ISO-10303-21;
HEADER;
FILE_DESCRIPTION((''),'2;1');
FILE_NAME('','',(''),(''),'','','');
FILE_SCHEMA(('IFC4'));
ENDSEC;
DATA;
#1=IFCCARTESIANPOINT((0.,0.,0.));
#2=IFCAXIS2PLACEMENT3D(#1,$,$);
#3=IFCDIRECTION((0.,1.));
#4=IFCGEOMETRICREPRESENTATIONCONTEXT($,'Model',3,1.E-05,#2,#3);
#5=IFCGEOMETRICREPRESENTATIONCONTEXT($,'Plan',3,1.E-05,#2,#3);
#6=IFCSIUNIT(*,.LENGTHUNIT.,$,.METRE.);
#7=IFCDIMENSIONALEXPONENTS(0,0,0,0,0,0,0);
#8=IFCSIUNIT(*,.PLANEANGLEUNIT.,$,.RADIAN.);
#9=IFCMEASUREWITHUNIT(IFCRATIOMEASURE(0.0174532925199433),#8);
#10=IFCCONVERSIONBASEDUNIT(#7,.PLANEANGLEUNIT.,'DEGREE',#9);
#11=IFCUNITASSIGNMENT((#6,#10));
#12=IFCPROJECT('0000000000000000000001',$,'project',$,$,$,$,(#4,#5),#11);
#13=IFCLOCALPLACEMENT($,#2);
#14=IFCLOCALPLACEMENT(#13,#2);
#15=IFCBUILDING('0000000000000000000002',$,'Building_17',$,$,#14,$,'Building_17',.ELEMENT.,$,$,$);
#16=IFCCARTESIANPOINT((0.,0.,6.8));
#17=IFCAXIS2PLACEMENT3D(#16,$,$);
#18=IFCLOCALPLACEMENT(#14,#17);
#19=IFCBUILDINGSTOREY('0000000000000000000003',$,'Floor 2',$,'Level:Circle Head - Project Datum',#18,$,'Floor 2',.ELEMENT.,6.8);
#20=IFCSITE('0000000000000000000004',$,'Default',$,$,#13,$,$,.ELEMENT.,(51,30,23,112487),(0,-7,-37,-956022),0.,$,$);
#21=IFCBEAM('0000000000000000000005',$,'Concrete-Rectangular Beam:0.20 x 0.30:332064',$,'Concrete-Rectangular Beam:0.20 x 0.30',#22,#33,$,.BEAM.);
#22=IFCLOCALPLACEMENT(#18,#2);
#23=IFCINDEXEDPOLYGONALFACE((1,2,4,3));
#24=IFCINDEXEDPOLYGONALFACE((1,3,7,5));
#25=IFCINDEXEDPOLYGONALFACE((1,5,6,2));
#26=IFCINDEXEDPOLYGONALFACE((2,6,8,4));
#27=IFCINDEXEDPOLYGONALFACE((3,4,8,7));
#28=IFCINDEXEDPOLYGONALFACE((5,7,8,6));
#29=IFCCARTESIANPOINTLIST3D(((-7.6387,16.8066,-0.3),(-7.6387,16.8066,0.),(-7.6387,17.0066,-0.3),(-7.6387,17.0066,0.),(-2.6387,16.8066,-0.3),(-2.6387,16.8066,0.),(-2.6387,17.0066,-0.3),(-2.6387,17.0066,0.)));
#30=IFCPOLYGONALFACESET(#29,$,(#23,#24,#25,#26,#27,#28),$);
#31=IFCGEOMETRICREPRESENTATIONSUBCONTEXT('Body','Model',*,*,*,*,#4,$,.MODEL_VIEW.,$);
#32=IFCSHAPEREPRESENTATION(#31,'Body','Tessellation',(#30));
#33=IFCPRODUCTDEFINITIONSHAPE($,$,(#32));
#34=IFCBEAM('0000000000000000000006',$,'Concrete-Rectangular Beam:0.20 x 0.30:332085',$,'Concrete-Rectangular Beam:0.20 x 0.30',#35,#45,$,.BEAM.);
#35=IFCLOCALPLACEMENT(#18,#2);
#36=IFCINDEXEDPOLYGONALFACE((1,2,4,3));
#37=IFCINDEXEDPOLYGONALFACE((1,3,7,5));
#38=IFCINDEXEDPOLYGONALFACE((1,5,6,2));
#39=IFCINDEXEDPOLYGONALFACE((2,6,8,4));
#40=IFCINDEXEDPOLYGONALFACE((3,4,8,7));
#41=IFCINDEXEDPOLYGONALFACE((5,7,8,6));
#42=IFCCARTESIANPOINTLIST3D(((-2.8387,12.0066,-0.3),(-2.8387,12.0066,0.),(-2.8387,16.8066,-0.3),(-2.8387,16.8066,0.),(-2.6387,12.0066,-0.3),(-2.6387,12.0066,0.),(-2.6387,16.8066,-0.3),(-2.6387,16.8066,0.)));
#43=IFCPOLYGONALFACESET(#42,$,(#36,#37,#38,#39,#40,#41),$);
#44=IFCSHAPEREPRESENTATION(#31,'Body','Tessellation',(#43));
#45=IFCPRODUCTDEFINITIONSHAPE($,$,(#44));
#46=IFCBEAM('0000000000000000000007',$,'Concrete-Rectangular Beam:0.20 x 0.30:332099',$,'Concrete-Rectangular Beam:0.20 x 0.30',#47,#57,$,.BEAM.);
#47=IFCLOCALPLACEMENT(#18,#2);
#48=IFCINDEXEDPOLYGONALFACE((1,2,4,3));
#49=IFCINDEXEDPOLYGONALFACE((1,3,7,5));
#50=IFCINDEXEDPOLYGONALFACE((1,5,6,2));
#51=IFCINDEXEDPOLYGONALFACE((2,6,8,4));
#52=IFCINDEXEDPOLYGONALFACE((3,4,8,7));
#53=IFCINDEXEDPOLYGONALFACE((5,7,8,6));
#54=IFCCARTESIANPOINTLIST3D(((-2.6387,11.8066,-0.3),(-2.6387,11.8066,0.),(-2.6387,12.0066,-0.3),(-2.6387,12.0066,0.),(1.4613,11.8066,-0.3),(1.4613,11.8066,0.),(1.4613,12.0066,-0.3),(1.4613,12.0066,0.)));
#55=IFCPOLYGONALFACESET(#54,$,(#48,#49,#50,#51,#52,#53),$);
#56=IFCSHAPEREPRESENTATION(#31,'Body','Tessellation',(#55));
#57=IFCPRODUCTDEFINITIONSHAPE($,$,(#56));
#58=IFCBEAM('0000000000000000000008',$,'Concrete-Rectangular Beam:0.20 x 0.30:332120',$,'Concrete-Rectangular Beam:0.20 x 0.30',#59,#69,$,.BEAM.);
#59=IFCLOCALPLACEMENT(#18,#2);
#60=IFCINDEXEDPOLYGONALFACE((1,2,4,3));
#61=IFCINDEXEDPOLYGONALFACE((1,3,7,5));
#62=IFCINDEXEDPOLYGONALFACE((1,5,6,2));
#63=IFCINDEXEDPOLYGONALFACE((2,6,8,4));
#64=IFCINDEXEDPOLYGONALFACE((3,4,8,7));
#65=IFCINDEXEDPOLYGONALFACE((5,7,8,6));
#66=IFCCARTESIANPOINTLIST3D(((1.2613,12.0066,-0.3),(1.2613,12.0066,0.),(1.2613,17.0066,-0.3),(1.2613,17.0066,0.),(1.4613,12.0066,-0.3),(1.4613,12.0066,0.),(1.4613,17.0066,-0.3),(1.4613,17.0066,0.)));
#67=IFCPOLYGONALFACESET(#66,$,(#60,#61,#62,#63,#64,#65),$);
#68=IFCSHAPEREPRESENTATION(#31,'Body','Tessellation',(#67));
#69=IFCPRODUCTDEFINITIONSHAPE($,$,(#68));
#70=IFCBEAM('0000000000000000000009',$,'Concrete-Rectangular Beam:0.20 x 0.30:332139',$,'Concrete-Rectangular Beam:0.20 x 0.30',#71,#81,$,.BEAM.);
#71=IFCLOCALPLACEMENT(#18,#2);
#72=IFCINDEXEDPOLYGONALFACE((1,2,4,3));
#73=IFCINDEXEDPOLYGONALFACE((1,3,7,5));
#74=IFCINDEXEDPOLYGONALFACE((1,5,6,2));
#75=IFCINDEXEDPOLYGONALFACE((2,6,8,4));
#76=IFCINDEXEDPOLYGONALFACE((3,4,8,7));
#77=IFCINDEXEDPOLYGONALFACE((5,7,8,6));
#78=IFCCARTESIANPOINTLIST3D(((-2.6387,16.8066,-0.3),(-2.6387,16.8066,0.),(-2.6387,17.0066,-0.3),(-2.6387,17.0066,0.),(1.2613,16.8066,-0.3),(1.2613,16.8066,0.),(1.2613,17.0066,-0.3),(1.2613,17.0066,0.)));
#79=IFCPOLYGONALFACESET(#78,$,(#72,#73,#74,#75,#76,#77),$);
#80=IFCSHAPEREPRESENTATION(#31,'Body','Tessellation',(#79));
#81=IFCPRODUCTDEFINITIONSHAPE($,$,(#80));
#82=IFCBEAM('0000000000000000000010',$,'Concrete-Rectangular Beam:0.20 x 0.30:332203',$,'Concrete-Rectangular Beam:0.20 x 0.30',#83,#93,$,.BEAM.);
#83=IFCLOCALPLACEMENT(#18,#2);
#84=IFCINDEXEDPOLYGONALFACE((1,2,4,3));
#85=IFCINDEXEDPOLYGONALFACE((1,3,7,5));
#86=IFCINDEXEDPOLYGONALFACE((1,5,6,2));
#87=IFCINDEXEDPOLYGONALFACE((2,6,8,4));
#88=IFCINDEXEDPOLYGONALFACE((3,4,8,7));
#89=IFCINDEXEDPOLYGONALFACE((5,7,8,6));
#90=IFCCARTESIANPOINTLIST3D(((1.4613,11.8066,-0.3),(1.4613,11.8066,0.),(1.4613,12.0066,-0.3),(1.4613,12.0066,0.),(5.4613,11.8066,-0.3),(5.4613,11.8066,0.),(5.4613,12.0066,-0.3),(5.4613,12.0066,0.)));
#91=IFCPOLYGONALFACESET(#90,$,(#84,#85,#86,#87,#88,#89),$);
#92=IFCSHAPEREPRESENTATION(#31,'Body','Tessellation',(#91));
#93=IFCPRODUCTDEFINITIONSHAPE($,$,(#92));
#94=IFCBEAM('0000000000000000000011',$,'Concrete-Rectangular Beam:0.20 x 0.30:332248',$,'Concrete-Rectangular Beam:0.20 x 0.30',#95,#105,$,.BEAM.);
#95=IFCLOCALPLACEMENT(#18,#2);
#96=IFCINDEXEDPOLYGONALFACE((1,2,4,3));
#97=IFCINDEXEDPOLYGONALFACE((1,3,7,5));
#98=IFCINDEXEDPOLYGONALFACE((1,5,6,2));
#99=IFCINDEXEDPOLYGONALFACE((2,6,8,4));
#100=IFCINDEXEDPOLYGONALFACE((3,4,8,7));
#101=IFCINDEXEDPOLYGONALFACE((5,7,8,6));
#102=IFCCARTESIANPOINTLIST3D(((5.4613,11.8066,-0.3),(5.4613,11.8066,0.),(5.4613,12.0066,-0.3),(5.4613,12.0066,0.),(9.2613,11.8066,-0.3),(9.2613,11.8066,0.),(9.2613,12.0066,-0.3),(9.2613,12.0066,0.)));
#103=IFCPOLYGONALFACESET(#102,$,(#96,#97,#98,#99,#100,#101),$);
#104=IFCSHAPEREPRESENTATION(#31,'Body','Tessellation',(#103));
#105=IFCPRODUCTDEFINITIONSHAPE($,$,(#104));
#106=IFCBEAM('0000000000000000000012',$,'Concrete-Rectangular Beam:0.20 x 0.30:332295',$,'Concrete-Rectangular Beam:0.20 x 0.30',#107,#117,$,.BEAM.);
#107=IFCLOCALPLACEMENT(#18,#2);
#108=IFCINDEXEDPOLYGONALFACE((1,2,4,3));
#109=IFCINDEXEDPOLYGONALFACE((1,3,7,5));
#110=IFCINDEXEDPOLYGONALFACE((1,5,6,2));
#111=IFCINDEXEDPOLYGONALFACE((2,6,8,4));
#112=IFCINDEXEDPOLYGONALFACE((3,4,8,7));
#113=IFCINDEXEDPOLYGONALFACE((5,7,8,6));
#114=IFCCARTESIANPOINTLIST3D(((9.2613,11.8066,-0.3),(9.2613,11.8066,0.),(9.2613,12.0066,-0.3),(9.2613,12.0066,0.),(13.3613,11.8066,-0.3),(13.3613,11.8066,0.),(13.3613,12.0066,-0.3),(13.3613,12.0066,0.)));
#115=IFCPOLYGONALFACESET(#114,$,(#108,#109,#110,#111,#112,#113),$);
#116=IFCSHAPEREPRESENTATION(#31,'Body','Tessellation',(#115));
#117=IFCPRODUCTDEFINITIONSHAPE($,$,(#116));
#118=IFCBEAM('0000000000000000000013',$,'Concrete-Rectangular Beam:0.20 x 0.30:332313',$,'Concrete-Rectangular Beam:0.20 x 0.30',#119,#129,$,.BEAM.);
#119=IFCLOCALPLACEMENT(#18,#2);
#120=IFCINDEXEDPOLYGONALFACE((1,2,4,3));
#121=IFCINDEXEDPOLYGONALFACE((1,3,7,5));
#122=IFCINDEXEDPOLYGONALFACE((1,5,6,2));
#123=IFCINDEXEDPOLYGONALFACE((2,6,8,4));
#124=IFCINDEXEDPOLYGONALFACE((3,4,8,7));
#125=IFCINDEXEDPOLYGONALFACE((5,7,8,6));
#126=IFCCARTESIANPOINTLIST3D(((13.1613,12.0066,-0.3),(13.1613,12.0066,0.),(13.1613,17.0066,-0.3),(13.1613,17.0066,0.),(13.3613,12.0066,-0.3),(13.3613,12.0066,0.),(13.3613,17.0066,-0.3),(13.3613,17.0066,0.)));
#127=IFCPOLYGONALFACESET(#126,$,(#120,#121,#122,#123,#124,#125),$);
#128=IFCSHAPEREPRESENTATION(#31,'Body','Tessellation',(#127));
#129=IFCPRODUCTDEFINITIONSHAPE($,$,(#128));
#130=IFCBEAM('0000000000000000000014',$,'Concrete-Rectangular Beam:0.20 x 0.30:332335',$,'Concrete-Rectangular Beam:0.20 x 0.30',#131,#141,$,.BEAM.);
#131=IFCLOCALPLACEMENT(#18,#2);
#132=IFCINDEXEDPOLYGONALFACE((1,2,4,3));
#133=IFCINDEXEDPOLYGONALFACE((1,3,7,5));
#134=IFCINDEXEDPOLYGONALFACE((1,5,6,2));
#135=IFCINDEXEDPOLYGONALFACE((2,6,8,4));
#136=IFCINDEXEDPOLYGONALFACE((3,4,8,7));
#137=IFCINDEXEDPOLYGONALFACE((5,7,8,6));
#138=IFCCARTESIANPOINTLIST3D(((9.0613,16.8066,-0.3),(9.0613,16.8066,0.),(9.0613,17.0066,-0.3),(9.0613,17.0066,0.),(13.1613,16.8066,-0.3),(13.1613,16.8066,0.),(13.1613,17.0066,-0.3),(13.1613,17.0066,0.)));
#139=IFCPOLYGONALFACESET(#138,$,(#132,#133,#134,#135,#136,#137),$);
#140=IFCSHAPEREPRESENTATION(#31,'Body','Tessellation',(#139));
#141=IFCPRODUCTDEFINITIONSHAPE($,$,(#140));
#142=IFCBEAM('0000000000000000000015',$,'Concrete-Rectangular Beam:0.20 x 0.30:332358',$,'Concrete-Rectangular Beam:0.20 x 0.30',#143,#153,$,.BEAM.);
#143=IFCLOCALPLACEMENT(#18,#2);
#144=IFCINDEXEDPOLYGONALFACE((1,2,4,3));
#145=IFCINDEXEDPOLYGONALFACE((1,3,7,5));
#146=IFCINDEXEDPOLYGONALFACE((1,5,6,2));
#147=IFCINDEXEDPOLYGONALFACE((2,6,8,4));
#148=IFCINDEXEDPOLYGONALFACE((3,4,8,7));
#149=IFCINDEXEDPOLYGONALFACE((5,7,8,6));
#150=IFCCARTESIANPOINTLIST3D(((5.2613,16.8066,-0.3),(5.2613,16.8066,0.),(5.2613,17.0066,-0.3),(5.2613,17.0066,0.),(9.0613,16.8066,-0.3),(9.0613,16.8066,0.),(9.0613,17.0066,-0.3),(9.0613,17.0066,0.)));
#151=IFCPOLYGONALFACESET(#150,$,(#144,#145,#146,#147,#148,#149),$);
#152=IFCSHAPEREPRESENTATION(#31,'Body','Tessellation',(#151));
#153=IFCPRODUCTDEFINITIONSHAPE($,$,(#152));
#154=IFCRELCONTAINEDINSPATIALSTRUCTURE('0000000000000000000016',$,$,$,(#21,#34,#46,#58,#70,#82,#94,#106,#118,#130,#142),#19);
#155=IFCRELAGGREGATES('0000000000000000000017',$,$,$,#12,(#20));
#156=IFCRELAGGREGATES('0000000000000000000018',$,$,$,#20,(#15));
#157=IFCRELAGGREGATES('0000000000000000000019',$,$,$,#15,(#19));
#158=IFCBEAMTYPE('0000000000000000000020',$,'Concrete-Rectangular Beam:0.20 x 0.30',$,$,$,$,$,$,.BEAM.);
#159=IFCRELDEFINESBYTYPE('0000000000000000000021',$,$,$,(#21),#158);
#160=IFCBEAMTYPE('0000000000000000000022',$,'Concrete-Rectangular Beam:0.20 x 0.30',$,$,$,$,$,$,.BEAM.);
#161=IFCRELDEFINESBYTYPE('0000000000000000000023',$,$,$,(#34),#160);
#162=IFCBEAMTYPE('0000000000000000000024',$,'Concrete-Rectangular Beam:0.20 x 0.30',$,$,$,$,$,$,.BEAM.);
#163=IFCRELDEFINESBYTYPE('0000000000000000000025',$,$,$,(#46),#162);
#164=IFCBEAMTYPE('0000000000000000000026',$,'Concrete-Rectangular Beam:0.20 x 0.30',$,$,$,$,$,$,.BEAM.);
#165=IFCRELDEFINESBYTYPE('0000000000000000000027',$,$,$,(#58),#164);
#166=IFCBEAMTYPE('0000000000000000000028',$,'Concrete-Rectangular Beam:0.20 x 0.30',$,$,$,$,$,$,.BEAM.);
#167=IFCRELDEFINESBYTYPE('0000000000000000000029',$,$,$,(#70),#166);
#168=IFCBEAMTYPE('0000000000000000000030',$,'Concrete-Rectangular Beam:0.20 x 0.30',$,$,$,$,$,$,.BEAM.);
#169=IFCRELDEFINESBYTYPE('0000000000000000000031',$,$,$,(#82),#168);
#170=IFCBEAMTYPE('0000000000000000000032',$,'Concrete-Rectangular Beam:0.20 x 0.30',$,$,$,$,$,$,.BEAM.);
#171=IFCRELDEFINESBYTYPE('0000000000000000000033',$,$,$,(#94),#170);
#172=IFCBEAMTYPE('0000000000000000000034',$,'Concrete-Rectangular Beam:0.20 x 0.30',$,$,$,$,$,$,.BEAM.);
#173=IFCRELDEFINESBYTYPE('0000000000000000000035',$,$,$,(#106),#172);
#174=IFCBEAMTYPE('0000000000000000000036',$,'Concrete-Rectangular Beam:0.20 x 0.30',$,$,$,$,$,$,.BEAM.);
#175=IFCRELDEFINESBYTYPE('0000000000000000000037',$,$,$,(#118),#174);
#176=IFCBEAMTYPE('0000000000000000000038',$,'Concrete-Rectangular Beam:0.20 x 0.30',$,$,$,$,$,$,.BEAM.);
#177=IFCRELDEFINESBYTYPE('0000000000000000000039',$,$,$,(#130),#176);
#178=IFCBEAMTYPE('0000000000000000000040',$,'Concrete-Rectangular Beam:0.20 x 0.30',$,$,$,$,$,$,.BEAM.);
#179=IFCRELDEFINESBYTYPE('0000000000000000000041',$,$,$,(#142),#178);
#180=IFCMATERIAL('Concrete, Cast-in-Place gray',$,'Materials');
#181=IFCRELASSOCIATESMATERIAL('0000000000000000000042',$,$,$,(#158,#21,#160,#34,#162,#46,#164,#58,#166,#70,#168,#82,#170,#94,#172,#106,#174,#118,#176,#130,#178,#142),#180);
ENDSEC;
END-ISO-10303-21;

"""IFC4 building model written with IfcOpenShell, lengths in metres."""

from ifc_helpers import new_model, entity, si_unit, converted_unit, direction, frame, origin, place, context, subcontext, project, spatial, indexed_curve, outline, extrude, source, transform, mapped, material, type_object, type_shapes, element, save


model = new_model("IFC4")

# Units and contexts
model_context = context("Model", 3, precision=1e-05, world=origin(), true_north=direction((0.0, 1.0)))
plan_context = context("Plan", 3, precision=1e-05, world=origin(), true_north=direction((0.0, 1.0)))
body_context = subcontext(model_context, "Body", "Model", "MODEL_VIEW")
ifc_project = project(units=[si_unit("LENGTHUNIT", "METRE"), converted_unit("PLANEANGLEUNIT", "DEGREE", entity("IfcRatioMeasure", 0.0174532925199433), si_unit("PLANEANGLEUNIT", "RADIAN"), dimensions=[0, 0, 0, 0, 0, 0, 0])], contexts=[model_context, plan_context])

# Site, building, storey
site_placement = place(None, origin())
site = spatial("IfcSite", under=ifc_project, at=site_placement, Name="Default", CompositionType="ELEMENT", RefLatitude=(51, 30, 23, 112487), RefLongitude=(0, -7, -37, -956022), RefElevation=0.0)
building_placement = place(site_placement, origin())
building = spatial("IfcBuilding", under=site, at=building_placement, Name="Building_17", LongName="Building_17", CompositionType="ELEMENT")
storey_placement = place(building_placement, frame((0.0, 0.0, 6.8)))
storey = spatial("IfcBuildingStorey", under=building, at=storey_placement, Name="Floor 2", ObjectType="Level:Circle Head - Project Datum", LongName="Floor 2", CompositionType="ELEMENT", Elevation=6.8)

# Beams
ifc_material_1 = material(Name="Concrete, Cast-in-Place gray", Category="Materials")
beam_type_1 = type_object("IfcBeamType", Name="Concrete-Rectangular Beam:0.20 x 0.30", PredefinedType="BEAM", material=ifc_material_1)
shared_shape_1 = source(origin(), body_context, "Body", "SweptSolid", [
    extrude(outline(indexed_curve([(-0.15, -0.1), (0.15, -0.1), (0.15, 0.1), (-0.15, 0.1), (-0.15, -0.1)], self_intersect=False)), frame((-7.6387, 16.9066, 6.65), z_axis=(1.0, 0.0, 0.0), x_axis=(0.0, 0.0, -1.0)), (0.0, 0.0, 1.0), 5.0),
])
type_shapes(beam_type_1, [shared_shape_1])
beam_1_placement = place(storey_placement, frame((0.0, 0.0, -6.8)))
element("IfcBeam", 1, at=beam_1_placement, inside=storey, type_object=beam_type_1, material=ifc_material_1, Name="Concrete-Rectangular Beam:0.20 x 0.30:332064", ObjectType="Concrete-Rectangular Beam:0.20 x 0.30", PredefinedType="BEAM", context=body_context, shape_type="MappedRepresentation", body=[
    mapped(shared_shape_1, transform((0.0, 0.0, 0.0), scale=1.0)),
])
beam_type_2 = type_object("IfcBeamType", Name="Concrete-Rectangular Beam:0.20 x 0.30", PredefinedType="BEAM", material=ifc_material_1)
shared_shape_2 = source(origin(), body_context, "Body", "SweptSolid", [
    extrude(outline(indexed_curve([(-0.1, -0.15), (0.1, -0.15), (0.1, 0.15), (-0.1, 0.15), (-0.1, -0.15)], self_intersect=False)), frame((-2.7387, 16.8066, 6.65), z_axis=(0.0, -1.0, 0.0), x_axis=(-1.0, 0.0, 0.0)), (0.0, 0.0, 1.0), 4.8),
])
type_shapes(beam_type_2, [shared_shape_2])
beam_2_placement = place(storey_placement, frame((0.0, 0.0, -6.8)))
element("IfcBeam", 2, at=beam_2_placement, inside=storey, type_object=beam_type_2, material=ifc_material_1, Name="Concrete-Rectangular Beam:0.20 x 0.30:332085", ObjectType="Concrete-Rectangular Beam:0.20 x 0.30", PredefinedType="BEAM", context=body_context, shape_type="MappedRepresentation", body=[
    mapped(shared_shape_2, transform((0.0, 0.0, 0.0), scale=1.0)),
])
beam_type_3 = type_object("IfcBeamType", Name="Concrete-Rectangular Beam:0.20 x 0.30", PredefinedType="BEAM", material=ifc_material_1)
shared_shape_3 = source(origin(), body_context, "Body", "SweptSolid", [
    extrude(outline(indexed_curve([(-0.15, -0.1), (0.15, -0.1), (0.15, 0.1), (-0.15, 0.1), (-0.15, -0.1)], self_intersect=False)), frame((-2.6387, 11.9066, 6.65), z_axis=(1.0, 0.0, 0.0), x_axis=(0.0, 0.0, -1.0)), (0.0, 0.0, 1.0), 4.1),
])
type_shapes(beam_type_3, [shared_shape_3])
beam_3_placement = place(storey_placement, frame((0.0, 0.0, -6.8)))
element("IfcBeam", 3, at=beam_3_placement, inside=storey, type_object=beam_type_3, material=ifc_material_1, Name="Concrete-Rectangular Beam:0.20 x 0.30:332099", ObjectType="Concrete-Rectangular Beam:0.20 x 0.30", PredefinedType="BEAM", context=body_context, shape_type="MappedRepresentation", body=[
    mapped(shared_shape_3, transform((0.0, 0.0, 0.0), scale=1.0)),
])
beam_type_4 = type_object("IfcBeamType", Name="Concrete-Rectangular Beam:0.20 x 0.30", PredefinedType="BEAM", material=ifc_material_1)
shared_shape_4 = source(origin(), body_context, "Body", "SweptSolid", [
    extrude(outline(indexed_curve([(-0.1, -0.15), (0.1, -0.15), (0.1, 0.15), (-0.1, 0.15), (-0.1, -0.15)], self_intersect=False)), frame((1.3613, 12.0066, 6.65), z_axis=(0.0, 1.0, 0.0), x_axis=(-1.0, 0.0, 0.0)), (0.0, 0.0, 1.0), 5.0),
])
type_shapes(beam_type_4, [shared_shape_4])
beam_4_placement = place(storey_placement, frame((0.0, 0.0, -6.8)))
element("IfcBeam", 4, at=beam_4_placement, inside=storey, type_object=beam_type_4, material=ifc_material_1, Name="Concrete-Rectangular Beam:0.20 x 0.30:332120", ObjectType="Concrete-Rectangular Beam:0.20 x 0.30", PredefinedType="BEAM", context=body_context, shape_type="MappedRepresentation", body=[
    mapped(shared_shape_4, transform((0.0, 0.0, 0.0), scale=1.0)),
])
beam_type_5 = type_object("IfcBeamType", Name="Concrete-Rectangular Beam:0.20 x 0.30", PredefinedType="BEAM", material=ifc_material_1)
shared_shape_5 = source(origin(), body_context, "Body", "SweptSolid", [
    extrude(outline(indexed_curve([(-0.15, -0.1), (0.15, -0.1), (0.15, 0.1), (-0.15, 0.1), (-0.15, -0.1)], self_intersect=False)), frame((1.2613, 16.9066, 6.65), z_axis=(-1.0, 0.0, 0.0), x_axis=(0.0, 0.0, -1.0)), (0.0, 0.0, 1.0), 3.9),
])
type_shapes(beam_type_5, [shared_shape_5])
beam_5_placement = place(storey_placement, frame((0.0, 0.0, -6.8)))
element("IfcBeam", 5, at=beam_5_placement, inside=storey, type_object=beam_type_5, material=ifc_material_1, Name="Concrete-Rectangular Beam:0.20 x 0.30:332139", ObjectType="Concrete-Rectangular Beam:0.20 x 0.30", PredefinedType="BEAM", context=body_context, shape_type="MappedRepresentation", body=[
    mapped(shared_shape_5, transform((0.0, 0.0, 0.0), scale=1.0)),
])
beam_type_6 = type_object("IfcBeamType", Name="Concrete-Rectangular Beam:0.20 x 0.30", PredefinedType="BEAM", material=ifc_material_1)
shared_shape_6 = source(origin(), body_context, "Body", "SweptSolid", [
    extrude(outline(indexed_curve([(-0.15, -0.1), (0.15, -0.1), (0.15, 0.1), (-0.15, 0.1), (-0.15, -0.1)], self_intersect=False)), frame((1.4613, 11.9066, 6.65), z_axis=(1.0, 0.0, 0.0), x_axis=(0.0, 0.0, -1.0)), (0.0, 0.0, 1.0), 4.0),
])
type_shapes(beam_type_6, [shared_shape_6])
beam_6_placement = place(storey_placement, frame((0.0, 0.0, -6.8)))
element("IfcBeam", 6, at=beam_6_placement, inside=storey, type_object=beam_type_6, material=ifc_material_1, Name="Concrete-Rectangular Beam:0.20 x 0.30:332203", ObjectType="Concrete-Rectangular Beam:0.20 x 0.30", PredefinedType="BEAM", context=body_context, shape_type="MappedRepresentation", body=[
    mapped(shared_shape_6, transform((0.0, 0.0, 0.0), scale=1.0)),
])
beam_type_7 = type_object("IfcBeamType", Name="Concrete-Rectangular Beam:0.20 x 0.30", PredefinedType="BEAM", material=ifc_material_1)
shared_shape_7 = source(origin(), body_context, "Body", "SweptSolid", [
    extrude(outline(indexed_curve([(-0.15, -0.1), (0.15, -0.1), (0.15, 0.1), (-0.15, 0.1), (-0.15, -0.1)], self_intersect=False)), frame((5.4613, 11.9066, 6.65), z_axis=(1.0, 0.0, 0.0), x_axis=(0.0, 0.0, -1.0)), (0.0, 0.0, 1.0), 3.8),
])
type_shapes(beam_type_7, [shared_shape_7])
beam_7_placement = place(storey_placement, frame((0.0, 0.0, -6.8)))
element("IfcBeam", 7, at=beam_7_placement, inside=storey, type_object=beam_type_7, material=ifc_material_1, Name="Concrete-Rectangular Beam:0.20 x 0.30:332248", ObjectType="Concrete-Rectangular Beam:0.20 x 0.30", PredefinedType="BEAM", context=body_context, shape_type="MappedRepresentation", body=[
    mapped(shared_shape_7, transform((0.0, 0.0, 0.0), scale=1.0)),
])
beam_type_8 = type_object("IfcBeamType", Name="Concrete-Rectangular Beam:0.20 x 0.30", PredefinedType="BEAM", material=ifc_material_1)
shared_shape_8 = source(origin(), body_context, "Body", "SweptSolid", [
    extrude(outline(indexed_curve([(-0.15, -0.1), (0.15, -0.1), (0.15, 0.1), (-0.15, 0.1), (-0.15, -0.1)], self_intersect=False)), frame((9.2613, 11.9066, 6.65), z_axis=(1.0, 0.0, 0.0), x_axis=(0.0, 0.0, -1.0)), (0.0, 0.0, 1.0), 4.1),
])
type_shapes(beam_type_8, [shared_shape_8])
beam_8_placement = place(storey_placement, frame((0.0, 0.0, -6.8)))
element("IfcBeam", 8, at=beam_8_placement, inside=storey, type_object=beam_type_8, material=ifc_material_1, Name="Concrete-Rectangular Beam:0.20 x 0.30:332295", ObjectType="Concrete-Rectangular Beam:0.20 x 0.30", PredefinedType="BEAM", context=body_context, shape_type="MappedRepresentation", body=[
    mapped(shared_shape_8, transform((0.0, 0.0, 0.0), scale=1.0)),
])
beam_type_9 = type_object("IfcBeamType", Name="Concrete-Rectangular Beam:0.20 x 0.30", PredefinedType="BEAM", material=ifc_material_1)
shared_shape_9 = source(origin(), body_context, "Body", "SweptSolid", [
    extrude(outline(indexed_curve([(-0.1, -0.15), (0.1, -0.15), (0.1, 0.15), (-0.1, 0.15), (-0.1, -0.15)], self_intersect=False)), frame((13.2613, 12.0066, 6.65), z_axis=(0.0, 1.0, 0.0), x_axis=(-1.0, 0.0, 0.0)), (0.0, 0.0, 1.0), 5.0),
])
type_shapes(beam_type_9, [shared_shape_9])
beam_9_placement = place(storey_placement, frame((0.0, 0.0, -6.8)))
element("IfcBeam", 9, at=beam_9_placement, inside=storey, type_object=beam_type_9, material=ifc_material_1, Name="Concrete-Rectangular Beam:0.20 x 0.30:332313", ObjectType="Concrete-Rectangular Beam:0.20 x 0.30", PredefinedType="BEAM", context=body_context, shape_type="MappedRepresentation", body=[
    mapped(shared_shape_9, transform((0.0, 0.0, 0.0), scale=1.0)),
])
beam_type_10 = type_object("IfcBeamType", Name="Concrete-Rectangular Beam:0.20 x 0.30", PredefinedType="BEAM", material=ifc_material_1)
shared_shape_10 = source(origin(), body_context, "Body", "SweptSolid", [
    extrude(outline(indexed_curve([(-0.15, -0.1), (0.15, -0.1), (0.15, 0.1), (-0.15, 0.1), (-0.15, -0.1)], self_intersect=False)), frame((13.1613, 16.9066, 6.65), z_axis=(-1.0, 0.0, 0.0), x_axis=(0.0, 0.0, -1.0)), (0.0, 0.0, 1.0), 4.1),
])
type_shapes(beam_type_10, [shared_shape_10])
beam_10_placement = place(storey_placement, frame((0.0, 0.0, -6.8)))
element("IfcBeam", 10, at=beam_10_placement, inside=storey, type_object=beam_type_10, material=ifc_material_1, Name="Concrete-Rectangular Beam:0.20 x 0.30:332335", ObjectType="Concrete-Rectangular Beam:0.20 x 0.30", PredefinedType="BEAM", context=body_context, shape_type="MappedRepresentation", body=[
    mapped(shared_shape_10, transform((0.0, 0.0, 0.0), scale=1.0)),
])
beam_type_11 = type_object("IfcBeamType", Name="Concrete-Rectangular Beam:0.20 x 0.30", PredefinedType="BEAM", material=ifc_material_1)
shared_shape_11 = source(origin(), body_context, "Body", "SweptSolid", [
    extrude(outline(indexed_curve([(-0.15, -0.1), (0.15, -0.1), (0.15, 0.1), (-0.15, 0.1), (-0.15, -0.1)], self_intersect=False)), frame((9.0613, 16.9066, 6.65), z_axis=(-1.0, 0.0, 0.0), x_axis=(0.0, 0.0, -1.0)), (0.0, 0.0, 1.0), 3.8),
])
type_shapes(beam_type_11, [shared_shape_11])
beam_11_placement = place(storey_placement, frame((0.0, 0.0, -6.8)))
element("IfcBeam", 11, at=beam_11_placement, inside=storey, type_object=beam_type_11, material=ifc_material_1, Name="Concrete-Rectangular Beam:0.20 x 0.30:332358", ObjectType="Concrete-Rectangular Beam:0.20 x 0.30", PredefinedType="BEAM", context=body_context, shape_type="MappedRepresentation", body=[
    mapped(shared_shape_11, transform((0.0, 0.0, 0.0), scale=1.0)),
])

save(model, "model.ifc")
